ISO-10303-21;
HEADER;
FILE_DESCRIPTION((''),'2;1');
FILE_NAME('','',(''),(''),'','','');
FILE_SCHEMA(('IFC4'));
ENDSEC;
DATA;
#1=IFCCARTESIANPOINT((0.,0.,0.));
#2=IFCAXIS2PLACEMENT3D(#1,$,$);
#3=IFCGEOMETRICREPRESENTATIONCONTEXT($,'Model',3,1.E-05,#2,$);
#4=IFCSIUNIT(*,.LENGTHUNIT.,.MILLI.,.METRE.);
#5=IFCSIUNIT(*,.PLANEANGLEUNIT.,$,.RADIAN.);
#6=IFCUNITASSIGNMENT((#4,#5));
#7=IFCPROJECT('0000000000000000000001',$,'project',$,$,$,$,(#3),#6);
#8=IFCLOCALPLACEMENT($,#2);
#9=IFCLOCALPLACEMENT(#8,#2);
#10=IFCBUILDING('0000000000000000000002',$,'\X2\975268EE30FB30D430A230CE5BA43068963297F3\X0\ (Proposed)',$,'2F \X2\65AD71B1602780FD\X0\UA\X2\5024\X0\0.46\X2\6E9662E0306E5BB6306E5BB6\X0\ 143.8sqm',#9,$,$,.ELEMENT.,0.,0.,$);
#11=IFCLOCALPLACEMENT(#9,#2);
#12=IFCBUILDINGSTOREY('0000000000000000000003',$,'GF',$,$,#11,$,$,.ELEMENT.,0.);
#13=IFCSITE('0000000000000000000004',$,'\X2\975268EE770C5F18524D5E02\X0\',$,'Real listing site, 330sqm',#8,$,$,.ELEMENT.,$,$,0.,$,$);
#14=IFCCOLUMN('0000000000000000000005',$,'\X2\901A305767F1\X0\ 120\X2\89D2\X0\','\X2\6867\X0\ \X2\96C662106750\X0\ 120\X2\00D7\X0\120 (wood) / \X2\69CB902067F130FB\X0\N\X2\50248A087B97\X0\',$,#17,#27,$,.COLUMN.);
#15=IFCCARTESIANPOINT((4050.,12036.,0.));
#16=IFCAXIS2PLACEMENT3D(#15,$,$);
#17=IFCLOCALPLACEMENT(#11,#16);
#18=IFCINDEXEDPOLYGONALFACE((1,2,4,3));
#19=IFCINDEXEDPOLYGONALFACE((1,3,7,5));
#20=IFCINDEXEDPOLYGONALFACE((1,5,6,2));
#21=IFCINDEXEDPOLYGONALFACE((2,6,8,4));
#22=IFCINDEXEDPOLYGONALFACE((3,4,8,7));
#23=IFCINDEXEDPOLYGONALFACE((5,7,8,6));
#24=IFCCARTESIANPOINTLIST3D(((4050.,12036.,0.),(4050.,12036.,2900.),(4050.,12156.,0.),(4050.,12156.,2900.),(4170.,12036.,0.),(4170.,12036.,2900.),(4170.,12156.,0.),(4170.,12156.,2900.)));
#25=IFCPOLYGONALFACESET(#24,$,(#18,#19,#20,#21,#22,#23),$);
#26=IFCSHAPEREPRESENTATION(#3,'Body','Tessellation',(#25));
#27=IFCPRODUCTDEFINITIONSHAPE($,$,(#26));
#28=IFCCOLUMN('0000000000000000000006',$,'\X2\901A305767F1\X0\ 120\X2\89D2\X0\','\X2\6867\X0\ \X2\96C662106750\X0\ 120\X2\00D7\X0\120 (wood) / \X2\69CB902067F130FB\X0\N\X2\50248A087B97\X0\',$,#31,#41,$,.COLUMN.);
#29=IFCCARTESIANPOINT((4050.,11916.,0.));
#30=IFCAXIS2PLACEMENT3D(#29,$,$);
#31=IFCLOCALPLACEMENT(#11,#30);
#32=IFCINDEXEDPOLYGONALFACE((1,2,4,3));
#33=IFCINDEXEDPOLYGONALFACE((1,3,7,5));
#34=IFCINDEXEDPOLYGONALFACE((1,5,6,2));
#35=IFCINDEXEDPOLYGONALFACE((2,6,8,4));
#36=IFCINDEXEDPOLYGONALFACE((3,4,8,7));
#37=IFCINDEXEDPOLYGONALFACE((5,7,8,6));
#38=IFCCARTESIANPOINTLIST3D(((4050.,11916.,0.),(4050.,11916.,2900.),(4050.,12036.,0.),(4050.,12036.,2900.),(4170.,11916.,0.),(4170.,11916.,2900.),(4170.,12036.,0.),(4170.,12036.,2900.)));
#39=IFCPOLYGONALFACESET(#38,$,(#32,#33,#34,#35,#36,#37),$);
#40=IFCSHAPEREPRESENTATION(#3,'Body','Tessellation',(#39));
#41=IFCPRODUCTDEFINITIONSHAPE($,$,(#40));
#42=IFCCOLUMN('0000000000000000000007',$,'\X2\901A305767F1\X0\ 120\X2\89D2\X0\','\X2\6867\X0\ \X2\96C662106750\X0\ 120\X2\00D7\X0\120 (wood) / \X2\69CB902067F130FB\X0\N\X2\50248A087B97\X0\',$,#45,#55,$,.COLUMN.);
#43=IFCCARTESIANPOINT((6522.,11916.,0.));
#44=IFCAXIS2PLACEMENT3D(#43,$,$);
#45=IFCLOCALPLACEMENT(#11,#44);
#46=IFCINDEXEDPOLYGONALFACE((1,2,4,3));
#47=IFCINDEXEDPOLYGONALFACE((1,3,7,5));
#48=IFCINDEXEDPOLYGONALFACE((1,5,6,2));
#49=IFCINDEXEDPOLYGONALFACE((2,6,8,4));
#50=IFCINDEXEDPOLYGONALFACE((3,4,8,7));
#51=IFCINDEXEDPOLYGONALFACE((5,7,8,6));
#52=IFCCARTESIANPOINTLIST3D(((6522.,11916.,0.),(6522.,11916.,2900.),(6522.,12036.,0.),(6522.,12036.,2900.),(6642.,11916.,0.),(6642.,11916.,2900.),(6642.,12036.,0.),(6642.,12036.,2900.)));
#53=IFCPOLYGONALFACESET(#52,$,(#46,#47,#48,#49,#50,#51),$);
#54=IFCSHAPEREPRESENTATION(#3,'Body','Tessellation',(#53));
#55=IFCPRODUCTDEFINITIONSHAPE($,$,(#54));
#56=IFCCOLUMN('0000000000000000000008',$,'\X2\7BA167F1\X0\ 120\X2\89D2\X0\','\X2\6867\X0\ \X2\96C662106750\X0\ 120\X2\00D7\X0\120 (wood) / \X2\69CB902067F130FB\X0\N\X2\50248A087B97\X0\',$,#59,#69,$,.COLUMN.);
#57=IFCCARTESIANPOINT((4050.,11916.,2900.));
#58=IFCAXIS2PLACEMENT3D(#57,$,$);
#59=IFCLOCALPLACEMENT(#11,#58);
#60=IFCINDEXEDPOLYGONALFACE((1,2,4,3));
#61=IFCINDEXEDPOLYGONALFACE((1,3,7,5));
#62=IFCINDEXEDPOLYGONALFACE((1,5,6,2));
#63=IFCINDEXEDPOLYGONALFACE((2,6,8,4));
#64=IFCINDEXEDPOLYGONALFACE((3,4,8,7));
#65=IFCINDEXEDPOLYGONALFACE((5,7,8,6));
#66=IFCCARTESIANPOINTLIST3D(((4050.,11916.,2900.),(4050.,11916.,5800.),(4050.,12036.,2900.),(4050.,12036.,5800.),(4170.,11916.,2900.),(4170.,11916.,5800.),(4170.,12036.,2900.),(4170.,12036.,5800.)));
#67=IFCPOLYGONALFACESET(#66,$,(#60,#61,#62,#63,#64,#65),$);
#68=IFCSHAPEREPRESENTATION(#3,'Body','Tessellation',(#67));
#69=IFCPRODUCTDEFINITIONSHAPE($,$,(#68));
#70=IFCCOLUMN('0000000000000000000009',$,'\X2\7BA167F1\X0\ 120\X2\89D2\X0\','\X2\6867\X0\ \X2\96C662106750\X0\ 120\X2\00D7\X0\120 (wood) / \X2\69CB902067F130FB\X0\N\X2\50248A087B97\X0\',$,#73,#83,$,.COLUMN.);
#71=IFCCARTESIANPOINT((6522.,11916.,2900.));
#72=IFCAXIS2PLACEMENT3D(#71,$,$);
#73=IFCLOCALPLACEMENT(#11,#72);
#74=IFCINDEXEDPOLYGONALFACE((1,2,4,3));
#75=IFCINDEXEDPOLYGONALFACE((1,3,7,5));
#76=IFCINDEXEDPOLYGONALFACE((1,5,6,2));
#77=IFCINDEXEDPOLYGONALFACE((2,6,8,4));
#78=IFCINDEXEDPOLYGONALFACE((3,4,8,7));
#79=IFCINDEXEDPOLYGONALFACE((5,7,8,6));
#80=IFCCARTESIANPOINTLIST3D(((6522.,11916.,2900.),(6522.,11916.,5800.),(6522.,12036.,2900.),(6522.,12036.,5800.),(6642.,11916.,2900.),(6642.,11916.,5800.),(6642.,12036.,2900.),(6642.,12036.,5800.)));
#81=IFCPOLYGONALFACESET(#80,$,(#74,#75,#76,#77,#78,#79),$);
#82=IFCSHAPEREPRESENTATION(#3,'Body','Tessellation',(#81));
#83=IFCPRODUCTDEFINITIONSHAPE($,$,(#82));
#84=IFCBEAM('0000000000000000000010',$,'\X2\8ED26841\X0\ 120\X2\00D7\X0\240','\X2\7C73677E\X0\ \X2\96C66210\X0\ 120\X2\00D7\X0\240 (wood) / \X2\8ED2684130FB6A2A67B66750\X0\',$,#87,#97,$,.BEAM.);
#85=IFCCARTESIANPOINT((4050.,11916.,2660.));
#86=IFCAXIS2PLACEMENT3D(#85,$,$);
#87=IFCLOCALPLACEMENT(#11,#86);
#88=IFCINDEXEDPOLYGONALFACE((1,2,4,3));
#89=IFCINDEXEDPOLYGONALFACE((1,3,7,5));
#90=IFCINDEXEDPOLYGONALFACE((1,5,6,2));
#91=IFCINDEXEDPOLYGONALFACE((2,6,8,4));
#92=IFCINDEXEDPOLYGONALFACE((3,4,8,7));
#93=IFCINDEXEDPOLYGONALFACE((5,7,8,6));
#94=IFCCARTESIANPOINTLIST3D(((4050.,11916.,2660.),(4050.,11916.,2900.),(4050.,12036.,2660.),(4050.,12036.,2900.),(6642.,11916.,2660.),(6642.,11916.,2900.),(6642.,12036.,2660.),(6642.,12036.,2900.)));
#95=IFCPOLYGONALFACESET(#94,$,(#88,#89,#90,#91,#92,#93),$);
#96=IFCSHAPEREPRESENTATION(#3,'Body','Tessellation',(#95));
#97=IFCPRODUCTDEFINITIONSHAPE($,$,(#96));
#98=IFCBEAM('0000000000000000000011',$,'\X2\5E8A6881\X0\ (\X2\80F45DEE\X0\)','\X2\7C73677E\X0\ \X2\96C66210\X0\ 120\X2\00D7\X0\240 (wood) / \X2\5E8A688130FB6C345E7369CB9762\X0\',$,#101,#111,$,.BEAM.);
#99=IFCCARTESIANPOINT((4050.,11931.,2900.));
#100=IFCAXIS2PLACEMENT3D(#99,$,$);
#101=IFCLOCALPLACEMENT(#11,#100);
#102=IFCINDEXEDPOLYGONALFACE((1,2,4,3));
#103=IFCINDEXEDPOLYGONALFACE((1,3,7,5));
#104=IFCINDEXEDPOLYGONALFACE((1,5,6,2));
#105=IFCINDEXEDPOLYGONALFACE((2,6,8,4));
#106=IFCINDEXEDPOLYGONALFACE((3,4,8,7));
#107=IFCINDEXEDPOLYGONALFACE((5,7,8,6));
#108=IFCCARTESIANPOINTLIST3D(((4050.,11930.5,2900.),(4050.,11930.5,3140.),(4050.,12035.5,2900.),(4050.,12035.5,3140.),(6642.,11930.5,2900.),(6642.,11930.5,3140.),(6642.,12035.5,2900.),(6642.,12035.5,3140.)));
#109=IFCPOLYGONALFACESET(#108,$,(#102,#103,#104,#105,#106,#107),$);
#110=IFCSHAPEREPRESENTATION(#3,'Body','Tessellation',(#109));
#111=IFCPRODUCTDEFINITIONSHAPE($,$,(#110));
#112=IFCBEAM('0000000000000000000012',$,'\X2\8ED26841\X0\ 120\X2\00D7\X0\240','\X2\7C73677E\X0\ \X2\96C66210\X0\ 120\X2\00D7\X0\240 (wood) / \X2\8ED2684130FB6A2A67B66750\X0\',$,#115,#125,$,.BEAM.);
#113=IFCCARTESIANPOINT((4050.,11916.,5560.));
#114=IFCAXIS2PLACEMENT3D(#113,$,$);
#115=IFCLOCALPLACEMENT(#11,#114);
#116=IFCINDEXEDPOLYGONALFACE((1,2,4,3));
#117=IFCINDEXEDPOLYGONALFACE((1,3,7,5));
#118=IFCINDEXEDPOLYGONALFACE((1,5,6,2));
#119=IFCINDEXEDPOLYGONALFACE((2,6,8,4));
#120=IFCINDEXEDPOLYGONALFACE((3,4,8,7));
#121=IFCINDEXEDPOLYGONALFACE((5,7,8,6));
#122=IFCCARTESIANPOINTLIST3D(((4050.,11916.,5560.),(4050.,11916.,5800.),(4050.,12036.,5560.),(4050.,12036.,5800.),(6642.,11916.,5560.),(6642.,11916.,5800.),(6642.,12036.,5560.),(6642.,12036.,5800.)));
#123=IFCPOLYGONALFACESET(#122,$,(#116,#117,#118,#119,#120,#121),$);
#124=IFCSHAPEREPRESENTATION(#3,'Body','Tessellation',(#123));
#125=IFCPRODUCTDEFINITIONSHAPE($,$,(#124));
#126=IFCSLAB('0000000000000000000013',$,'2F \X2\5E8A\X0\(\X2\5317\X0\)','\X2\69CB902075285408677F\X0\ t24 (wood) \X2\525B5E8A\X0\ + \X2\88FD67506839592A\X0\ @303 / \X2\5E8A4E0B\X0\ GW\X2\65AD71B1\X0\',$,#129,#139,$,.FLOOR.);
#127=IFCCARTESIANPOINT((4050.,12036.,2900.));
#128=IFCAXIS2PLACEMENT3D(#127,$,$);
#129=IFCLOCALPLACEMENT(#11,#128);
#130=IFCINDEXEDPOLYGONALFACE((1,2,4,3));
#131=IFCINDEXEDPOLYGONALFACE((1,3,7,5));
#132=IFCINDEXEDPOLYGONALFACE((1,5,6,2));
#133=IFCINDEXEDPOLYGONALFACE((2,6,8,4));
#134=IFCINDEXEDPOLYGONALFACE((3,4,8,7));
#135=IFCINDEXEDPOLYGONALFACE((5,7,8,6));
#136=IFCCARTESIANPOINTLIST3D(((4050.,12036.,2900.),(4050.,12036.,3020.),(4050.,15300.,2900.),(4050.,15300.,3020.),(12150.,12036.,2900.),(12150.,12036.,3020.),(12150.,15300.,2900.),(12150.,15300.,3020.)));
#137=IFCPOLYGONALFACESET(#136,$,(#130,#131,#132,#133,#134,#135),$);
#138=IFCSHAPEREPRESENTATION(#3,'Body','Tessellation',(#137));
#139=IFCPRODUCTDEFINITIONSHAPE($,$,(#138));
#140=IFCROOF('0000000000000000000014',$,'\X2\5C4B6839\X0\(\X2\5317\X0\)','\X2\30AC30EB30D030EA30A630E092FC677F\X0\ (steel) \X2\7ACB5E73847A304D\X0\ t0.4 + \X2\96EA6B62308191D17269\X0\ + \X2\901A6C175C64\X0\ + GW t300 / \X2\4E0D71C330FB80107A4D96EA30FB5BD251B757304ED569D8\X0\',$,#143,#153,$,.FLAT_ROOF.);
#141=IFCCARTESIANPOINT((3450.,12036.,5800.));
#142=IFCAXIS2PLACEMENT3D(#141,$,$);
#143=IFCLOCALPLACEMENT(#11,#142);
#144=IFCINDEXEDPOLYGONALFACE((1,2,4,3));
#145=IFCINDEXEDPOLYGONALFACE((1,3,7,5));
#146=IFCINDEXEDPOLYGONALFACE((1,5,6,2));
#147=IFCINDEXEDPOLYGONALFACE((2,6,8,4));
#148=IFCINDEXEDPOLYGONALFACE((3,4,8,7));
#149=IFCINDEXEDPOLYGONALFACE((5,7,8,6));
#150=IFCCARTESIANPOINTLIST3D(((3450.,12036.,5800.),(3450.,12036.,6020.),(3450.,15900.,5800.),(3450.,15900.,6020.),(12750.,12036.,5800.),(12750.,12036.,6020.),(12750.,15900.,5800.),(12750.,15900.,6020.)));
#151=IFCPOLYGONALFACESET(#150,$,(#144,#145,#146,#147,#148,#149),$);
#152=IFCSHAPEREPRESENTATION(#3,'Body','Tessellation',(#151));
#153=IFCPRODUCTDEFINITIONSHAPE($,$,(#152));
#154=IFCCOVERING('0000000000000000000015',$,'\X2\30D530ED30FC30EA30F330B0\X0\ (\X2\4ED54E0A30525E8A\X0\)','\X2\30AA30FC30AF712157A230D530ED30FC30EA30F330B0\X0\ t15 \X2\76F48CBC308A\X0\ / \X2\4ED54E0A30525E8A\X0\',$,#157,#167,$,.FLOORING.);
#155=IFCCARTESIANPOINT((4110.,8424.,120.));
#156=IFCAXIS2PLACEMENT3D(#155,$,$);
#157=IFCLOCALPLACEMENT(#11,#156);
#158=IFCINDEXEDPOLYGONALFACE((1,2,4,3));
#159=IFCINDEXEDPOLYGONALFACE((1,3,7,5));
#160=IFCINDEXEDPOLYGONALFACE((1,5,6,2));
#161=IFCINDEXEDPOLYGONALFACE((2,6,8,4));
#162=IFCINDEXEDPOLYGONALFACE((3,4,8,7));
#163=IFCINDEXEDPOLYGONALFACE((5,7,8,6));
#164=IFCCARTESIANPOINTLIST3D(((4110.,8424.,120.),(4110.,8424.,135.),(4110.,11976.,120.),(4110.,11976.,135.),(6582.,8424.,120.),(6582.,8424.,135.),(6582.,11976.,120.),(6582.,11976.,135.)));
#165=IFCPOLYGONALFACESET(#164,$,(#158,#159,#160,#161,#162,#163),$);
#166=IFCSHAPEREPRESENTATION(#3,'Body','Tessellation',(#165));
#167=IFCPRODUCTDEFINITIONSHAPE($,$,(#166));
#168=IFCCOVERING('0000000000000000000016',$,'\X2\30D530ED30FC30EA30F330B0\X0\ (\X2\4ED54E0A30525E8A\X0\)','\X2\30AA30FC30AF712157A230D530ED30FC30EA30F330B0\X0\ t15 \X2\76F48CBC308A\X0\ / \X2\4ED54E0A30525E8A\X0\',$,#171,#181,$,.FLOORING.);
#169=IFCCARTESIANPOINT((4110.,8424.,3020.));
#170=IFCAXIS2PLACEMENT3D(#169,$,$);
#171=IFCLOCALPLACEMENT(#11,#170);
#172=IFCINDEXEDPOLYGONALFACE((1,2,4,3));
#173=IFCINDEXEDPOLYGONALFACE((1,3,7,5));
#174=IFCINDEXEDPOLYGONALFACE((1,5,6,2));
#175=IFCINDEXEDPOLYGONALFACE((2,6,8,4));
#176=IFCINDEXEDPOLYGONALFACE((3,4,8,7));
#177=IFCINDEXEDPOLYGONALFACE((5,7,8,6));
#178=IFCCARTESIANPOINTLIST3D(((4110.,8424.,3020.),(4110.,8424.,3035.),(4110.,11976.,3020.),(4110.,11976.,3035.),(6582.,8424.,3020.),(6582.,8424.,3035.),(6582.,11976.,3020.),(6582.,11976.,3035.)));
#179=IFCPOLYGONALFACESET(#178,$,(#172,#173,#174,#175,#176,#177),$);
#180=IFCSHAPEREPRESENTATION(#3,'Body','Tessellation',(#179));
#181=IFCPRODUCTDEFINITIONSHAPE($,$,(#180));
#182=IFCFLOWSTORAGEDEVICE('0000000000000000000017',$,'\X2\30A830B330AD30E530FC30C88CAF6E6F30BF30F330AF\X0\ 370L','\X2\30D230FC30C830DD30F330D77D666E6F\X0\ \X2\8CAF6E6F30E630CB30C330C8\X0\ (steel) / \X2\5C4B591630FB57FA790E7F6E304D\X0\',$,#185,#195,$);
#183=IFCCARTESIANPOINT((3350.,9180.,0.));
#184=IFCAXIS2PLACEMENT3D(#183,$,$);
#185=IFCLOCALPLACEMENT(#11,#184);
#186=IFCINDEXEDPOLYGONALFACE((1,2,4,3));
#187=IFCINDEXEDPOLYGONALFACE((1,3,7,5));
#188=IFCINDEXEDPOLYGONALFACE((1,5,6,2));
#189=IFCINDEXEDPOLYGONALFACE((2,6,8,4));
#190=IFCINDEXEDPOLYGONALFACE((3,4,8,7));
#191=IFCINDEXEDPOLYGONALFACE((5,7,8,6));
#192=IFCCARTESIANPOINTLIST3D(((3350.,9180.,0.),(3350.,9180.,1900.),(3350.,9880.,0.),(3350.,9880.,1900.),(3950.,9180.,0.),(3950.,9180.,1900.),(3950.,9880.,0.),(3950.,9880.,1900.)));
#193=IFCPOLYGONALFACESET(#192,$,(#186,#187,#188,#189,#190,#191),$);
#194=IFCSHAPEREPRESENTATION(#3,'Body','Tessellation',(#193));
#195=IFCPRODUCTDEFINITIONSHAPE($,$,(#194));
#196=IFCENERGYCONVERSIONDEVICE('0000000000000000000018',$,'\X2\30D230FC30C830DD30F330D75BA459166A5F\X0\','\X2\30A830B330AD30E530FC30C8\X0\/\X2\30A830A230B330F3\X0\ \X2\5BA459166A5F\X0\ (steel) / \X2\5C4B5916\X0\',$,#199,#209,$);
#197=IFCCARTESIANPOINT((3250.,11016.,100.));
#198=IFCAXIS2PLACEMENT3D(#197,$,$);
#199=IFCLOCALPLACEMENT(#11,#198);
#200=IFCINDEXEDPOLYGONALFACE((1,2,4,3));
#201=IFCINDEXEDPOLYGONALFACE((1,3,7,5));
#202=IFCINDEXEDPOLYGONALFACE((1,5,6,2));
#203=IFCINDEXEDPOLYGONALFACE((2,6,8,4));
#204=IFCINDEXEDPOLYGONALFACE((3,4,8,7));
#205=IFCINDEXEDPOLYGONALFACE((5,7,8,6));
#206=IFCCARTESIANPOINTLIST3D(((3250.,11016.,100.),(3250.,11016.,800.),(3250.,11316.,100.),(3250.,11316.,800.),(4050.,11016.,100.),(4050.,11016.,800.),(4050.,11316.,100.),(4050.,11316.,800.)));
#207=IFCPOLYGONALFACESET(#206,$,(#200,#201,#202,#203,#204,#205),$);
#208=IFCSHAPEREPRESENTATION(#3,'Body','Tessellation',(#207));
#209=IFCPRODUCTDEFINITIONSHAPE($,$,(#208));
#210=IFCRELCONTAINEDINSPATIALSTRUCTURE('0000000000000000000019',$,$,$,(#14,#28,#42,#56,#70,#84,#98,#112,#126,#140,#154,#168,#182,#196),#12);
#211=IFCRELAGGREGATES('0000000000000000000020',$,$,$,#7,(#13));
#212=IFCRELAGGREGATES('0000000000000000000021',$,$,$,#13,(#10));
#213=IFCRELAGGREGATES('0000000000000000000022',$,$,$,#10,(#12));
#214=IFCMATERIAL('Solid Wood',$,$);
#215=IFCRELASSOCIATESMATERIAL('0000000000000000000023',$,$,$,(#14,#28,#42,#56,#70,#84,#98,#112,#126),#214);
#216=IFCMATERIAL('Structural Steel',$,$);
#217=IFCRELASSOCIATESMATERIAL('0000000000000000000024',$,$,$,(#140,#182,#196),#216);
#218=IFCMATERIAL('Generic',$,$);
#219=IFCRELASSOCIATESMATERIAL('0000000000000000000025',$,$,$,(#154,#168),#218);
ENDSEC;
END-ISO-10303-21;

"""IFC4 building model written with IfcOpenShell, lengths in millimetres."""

from ifc_helpers import new_model, si_unit, frame, frame_2d, origin, place, context, project, spatial, rectangle, extrude, material, element, save


model = new_model("IFC4")

# Units and contexts
model_context = context("Model", 3, precision=1e-05, world=origin())
ifc_project = project(units=[si_unit("LENGTHUNIT", "METRE", prefix="MILLI"), si_unit("PLANEANGLEUNIT", "RADIAN")], contexts=[model_context])

# Site, building, storey
site_placement = place(None, origin())
site = spatial("IfcSite", under=ifc_project, at=site_placement, Name="青森県弘前市", ObjectType="Real listing site, 330sqm", CompositionType="ELEMENT", RefElevation=0.0)
building_placement = place(site_placement, origin())
building = spatial("IfcBuilding", under=site, at=building_placement, Name="青森・ピアノ室と防音 (Proposed)", ObjectType="2F 断熱性能UA値0.46準拠の家の家 143.8sqm", CompositionType="ELEMENT", ElevationOfRefHeight=0.0, ElevationOfTerrain=0.0)
storey_placement = place(building_placement, origin())
storey = spatial("IfcBuildingStorey", under=building, at=storey_placement, Name="GF", CompositionType="ELEMENT", Elevation=0.0)

# Columns
ifc_material_1 = material(Name="Solid Wood")
column_1_placement = place(storey_placement, frame((4050.0, 12036.0, 0.0)))
element("IfcColumn", 1, at=column_1_placement, inside=storey, material=ifc_material_1, Name="通し柱 120角", Description="桧 集成材 120×120 (wood) / 構造柱・N値計算", PredefinedType="COLUMN", context=model_context, shape_type="SweptSolid", body=[
    extrude(rectangle(XDim=120.0, YDim=120.0, at=frame_2d((60.0, 60.0))), frame((4050.0, 12036.0, 0.0)), (0.0, 0.0, 1.0), 2900.0),
])
column_2_placement = place(storey_placement, frame((4050.0, 11916.0, 0.0)))
element("IfcColumn", 2, at=column_2_placement, inside=storey, material=ifc_material_1, Name="通し柱 120角", Description="桧 集成材 120×120 (wood) / 構造柱・N値計算", PredefinedType="COLUMN", context=model_context, shape_type="SweptSolid", body=[
    extrude(rectangle(XDim=120.0, YDim=120.0, at=frame_2d((60.0, 60.0))), frame((4050.0, 11916.0, 0.0)), (0.0, 0.0, 1.0), 2900.0),
])
column_3_placement = place(storey_placement, frame((6522.0, 11916.0, 0.0)))
element("IfcColumn", 3, at=column_3_placement, inside=storey, material=ifc_material_1, Name="通し柱 120角", Description="桧 集成材 120×120 (wood) / 構造柱・N値計算", PredefinedType="COLUMN", context=model_context, shape_type="SweptSolid", body=[
    extrude(rectangle(XDim=120.0, YDim=120.0, at=frame_2d((60.0, 60.0))), frame((6522.0, 11916.0, 0.0)), (0.0, 0.0, 1.0), 2900.0),
])
column_4_placement = place(storey_placement, frame((4050.0, 11916.0, 2900.0)))
element("IfcColumn", 4, at=column_4_placement, inside=storey, material=ifc_material_1, Name="管柱 120角", Description="桧 集成材 120×120 (wood) / 構造柱・N値計算", PredefinedType="COLUMN", context=model_context, shape_type="SweptSolid", body=[
    extrude(rectangle(XDim=120.0, YDim=120.0, at=frame_2d((60.0, 60.0))), frame((4050.0, 11916.0, 2900.0)), (0.0, 0.0, 1.0), 2900.0),
])
column_5_placement = place(storey_placement, frame((6522.0, 11916.0, 2900.0)))
element("IfcColumn", 5, at=column_5_placement, inside=storey, material=ifc_material_1, Name="管柱 120角", Description="桧 集成材 120×120 (wood) / 構造柱・N値計算", PredefinedType="COLUMN", context=model_context, shape_type="SweptSolid", body=[
    extrude(rectangle(XDim=120.0, YDim=120.0, at=frame_2d((60.0, 60.0))), frame((6522.0, 11916.0, 2900.0)), (0.0, 0.0, 1.0), 2900.0),
])

# Beams
beam_1_placement = place(storey_placement, frame((4050.0, 11916.0, 2660.0)))
element("IfcBeam", 6, at=beam_1_placement, inside=storey, material=ifc_material_1, Name="軒桁 120×240", Description="米松 集成 120×240 (wood) / 軒桁・横架材", PredefinedType="BEAM", context=model_context, shape_type="SweptSolid", body=[
    extrude(rectangle(XDim=2592.0, YDim=120.0, at=frame_2d((1296.0, 60.0))), frame((4050.0, 11916.0, 2660.0)), (0.0, 0.0, 1.0), 240.0),
])
beam_2_placement = place(storey_placement, frame((4050.0, 11931.0, 2900.0)))
element("IfcBeam", 7, at=beam_2_placement, inside=storey, material=ifc_material_1, Name="床梁 (胴差)", Description="米松 集成 120×240 (wood) / 床梁・水平構面", PredefinedType="BEAM", context=model_context, shape_type="SweptSolid", body=[
    extrude(rectangle(XDim=2592.0, YDim=105.0, at=frame_2d((1296.0, 52.0))), frame((4050.0, 11931.0, 2900.0)), (0.0, 0.0, 1.0), 240.0),
])
beam_3_placement = place(storey_placement, frame((4050.0, 11916.0, 5560.0)))
element("IfcBeam", 8, at=beam_3_placement, inside=storey, material=ifc_material_1, Name="軒桁 120×240", Description="米松 集成 120×240 (wood) / 軒桁・横架材", PredefinedType="BEAM", context=model_context, shape_type="SweptSolid", body=[
    extrude(rectangle(XDim=2592.0, YDim=120.0, at=frame_2d((1296.0, 60.0))), frame((4050.0, 11916.0, 5560.0)), (0.0, 0.0, 1.0), 240.0),
])

# Slab
slab_1_placement = place(storey_placement, frame((4050.0, 12036.0, 2900.0)))
element("IfcSlab", 9, at=slab_1_placement, inside=storey, material=ifc_material_1, Name="2F 床(北)", Description="構造用合板 t24 (wood) 剛床 + 製材根太 @303 / 床下 GW断熱", PredefinedType="FLOOR", context=model_context, shape_type="SweptSolid", body=[
    extrude(rectangle(XDim=8100.0, YDim=3264.0, at=frame_2d((4050.0, 1632.0))), frame((4050.0, 12036.0, 2900.0)), (0.0, 0.0, 1.0), 120.0),
])

# Roof
ifc_material_2 = material(Name="Structural Steel")
for number, where, name in (
    (10, (3450.0, 12036.0, 5800.0), "屋根(北)"),
):
    element("IfcRoof", number, at=place(storey_placement, frame(where)), inside=storey, material=ifc_material_2, Name=name, Description="ガルバリウム鋼板 (steel) 立平葺き t0.4 + 雪止め金物 + 通気層 + GW t300 / 不燃・耐積雪・寒冷地仕様", PredefinedType="FLAT_ROOF", context=model_context, shape_type="SweptSolid", body=[
        extrude(rectangle(XDim=9300.0, YDim=3864.0, at=frame_2d((4650.0, 1932.0))), frame((3450.0, 12036.0, 5800.0)), (0.0, 0.0, 1.0), 220.0),
    ])

# Coverings
ifc_material_3 = material(Name="Generic")
covering_1_placement = place(storey_placement, frame((4110.0, 8424.0, 120.0)))
element("IfcCovering", 11, at=covering_1_placement, inside=storey, material=ifc_material_3, Name="フローリング (仕上げ床)", Description="オーク無垢フローリング t15 直貼り / 仕上げ床", PredefinedType="FLOORING", context=model_context, shape_type="SweptSolid", body=[
    extrude(rectangle(XDim=2472.0, YDim=3552.0, at=frame_2d((1236.0, 1776.0))), frame((4110.0, 8424.0, 120.0)), (0.0, 0.0, 1.0), 15.0),
])
covering_2_placement = place(storey_placement, frame((4110.0, 8424.0, 3020.0)))
element("IfcCovering", 12, at=covering_2_placement, inside=storey, material=ifc_material_3, Name="フローリング (仕上げ床)", Description="オーク無垢フローリング t15 直貼り / 仕上げ床", PredefinedType="FLOORING", context=model_context, shape_type="SweptSolid", body=[
    extrude(rectangle(XDim=2472.0, YDim=3552.0, at=frame_2d((1236.0, 1776.0))), frame((4110.0, 8424.0, 3020.0)), (0.0, 0.0, 1.0), 15.0),
])

# Flow storage device
flow_storage_device_placement = place(storey_placement, frame((3350.0, 9180.0, 0.0)))
element("IfcFlowStorageDevice", 13, at=flow_storage_device_placement, inside=storey, material=ifc_material_2, Name="エコキュート貯湯タンク 370L", Description="ヒートポンプ給湯 貯湯ユニット (steel) / 屋外・基礎置き", context=model_context, shape_type="SweptSolid", body=[
    extrude(rectangle(XDim=600.0, YDim=700.0, at=frame_2d((300.0, 350.0))), frame((3350.0, 9180.0, 0.0)), (0.0, 0.0, 1.0), 1900.0),
])

# Energy conversion device
energy_conversion_device_placement = place(storey_placement, frame((3250.0, 11016.0, 100.0)))
element("IfcEnergyConversionDevice", 14, at=energy_conversion_device_placement, inside=storey, material=ifc_material_2, Name="ヒートポンプ室外機", Description="エコキュート/エアコン 室外機 (steel) / 屋外", context=model_context, shape_type="SweptSolid", body=[
    extrude(rectangle(XDim=800.0, YDim=300.0, at=frame_2d((400.0, 150.0))), frame((3250.0, 11016.0, 100.0)), (0.0, 0.0, 1.0), 700.0),
])

save(model, "model.ifc")
